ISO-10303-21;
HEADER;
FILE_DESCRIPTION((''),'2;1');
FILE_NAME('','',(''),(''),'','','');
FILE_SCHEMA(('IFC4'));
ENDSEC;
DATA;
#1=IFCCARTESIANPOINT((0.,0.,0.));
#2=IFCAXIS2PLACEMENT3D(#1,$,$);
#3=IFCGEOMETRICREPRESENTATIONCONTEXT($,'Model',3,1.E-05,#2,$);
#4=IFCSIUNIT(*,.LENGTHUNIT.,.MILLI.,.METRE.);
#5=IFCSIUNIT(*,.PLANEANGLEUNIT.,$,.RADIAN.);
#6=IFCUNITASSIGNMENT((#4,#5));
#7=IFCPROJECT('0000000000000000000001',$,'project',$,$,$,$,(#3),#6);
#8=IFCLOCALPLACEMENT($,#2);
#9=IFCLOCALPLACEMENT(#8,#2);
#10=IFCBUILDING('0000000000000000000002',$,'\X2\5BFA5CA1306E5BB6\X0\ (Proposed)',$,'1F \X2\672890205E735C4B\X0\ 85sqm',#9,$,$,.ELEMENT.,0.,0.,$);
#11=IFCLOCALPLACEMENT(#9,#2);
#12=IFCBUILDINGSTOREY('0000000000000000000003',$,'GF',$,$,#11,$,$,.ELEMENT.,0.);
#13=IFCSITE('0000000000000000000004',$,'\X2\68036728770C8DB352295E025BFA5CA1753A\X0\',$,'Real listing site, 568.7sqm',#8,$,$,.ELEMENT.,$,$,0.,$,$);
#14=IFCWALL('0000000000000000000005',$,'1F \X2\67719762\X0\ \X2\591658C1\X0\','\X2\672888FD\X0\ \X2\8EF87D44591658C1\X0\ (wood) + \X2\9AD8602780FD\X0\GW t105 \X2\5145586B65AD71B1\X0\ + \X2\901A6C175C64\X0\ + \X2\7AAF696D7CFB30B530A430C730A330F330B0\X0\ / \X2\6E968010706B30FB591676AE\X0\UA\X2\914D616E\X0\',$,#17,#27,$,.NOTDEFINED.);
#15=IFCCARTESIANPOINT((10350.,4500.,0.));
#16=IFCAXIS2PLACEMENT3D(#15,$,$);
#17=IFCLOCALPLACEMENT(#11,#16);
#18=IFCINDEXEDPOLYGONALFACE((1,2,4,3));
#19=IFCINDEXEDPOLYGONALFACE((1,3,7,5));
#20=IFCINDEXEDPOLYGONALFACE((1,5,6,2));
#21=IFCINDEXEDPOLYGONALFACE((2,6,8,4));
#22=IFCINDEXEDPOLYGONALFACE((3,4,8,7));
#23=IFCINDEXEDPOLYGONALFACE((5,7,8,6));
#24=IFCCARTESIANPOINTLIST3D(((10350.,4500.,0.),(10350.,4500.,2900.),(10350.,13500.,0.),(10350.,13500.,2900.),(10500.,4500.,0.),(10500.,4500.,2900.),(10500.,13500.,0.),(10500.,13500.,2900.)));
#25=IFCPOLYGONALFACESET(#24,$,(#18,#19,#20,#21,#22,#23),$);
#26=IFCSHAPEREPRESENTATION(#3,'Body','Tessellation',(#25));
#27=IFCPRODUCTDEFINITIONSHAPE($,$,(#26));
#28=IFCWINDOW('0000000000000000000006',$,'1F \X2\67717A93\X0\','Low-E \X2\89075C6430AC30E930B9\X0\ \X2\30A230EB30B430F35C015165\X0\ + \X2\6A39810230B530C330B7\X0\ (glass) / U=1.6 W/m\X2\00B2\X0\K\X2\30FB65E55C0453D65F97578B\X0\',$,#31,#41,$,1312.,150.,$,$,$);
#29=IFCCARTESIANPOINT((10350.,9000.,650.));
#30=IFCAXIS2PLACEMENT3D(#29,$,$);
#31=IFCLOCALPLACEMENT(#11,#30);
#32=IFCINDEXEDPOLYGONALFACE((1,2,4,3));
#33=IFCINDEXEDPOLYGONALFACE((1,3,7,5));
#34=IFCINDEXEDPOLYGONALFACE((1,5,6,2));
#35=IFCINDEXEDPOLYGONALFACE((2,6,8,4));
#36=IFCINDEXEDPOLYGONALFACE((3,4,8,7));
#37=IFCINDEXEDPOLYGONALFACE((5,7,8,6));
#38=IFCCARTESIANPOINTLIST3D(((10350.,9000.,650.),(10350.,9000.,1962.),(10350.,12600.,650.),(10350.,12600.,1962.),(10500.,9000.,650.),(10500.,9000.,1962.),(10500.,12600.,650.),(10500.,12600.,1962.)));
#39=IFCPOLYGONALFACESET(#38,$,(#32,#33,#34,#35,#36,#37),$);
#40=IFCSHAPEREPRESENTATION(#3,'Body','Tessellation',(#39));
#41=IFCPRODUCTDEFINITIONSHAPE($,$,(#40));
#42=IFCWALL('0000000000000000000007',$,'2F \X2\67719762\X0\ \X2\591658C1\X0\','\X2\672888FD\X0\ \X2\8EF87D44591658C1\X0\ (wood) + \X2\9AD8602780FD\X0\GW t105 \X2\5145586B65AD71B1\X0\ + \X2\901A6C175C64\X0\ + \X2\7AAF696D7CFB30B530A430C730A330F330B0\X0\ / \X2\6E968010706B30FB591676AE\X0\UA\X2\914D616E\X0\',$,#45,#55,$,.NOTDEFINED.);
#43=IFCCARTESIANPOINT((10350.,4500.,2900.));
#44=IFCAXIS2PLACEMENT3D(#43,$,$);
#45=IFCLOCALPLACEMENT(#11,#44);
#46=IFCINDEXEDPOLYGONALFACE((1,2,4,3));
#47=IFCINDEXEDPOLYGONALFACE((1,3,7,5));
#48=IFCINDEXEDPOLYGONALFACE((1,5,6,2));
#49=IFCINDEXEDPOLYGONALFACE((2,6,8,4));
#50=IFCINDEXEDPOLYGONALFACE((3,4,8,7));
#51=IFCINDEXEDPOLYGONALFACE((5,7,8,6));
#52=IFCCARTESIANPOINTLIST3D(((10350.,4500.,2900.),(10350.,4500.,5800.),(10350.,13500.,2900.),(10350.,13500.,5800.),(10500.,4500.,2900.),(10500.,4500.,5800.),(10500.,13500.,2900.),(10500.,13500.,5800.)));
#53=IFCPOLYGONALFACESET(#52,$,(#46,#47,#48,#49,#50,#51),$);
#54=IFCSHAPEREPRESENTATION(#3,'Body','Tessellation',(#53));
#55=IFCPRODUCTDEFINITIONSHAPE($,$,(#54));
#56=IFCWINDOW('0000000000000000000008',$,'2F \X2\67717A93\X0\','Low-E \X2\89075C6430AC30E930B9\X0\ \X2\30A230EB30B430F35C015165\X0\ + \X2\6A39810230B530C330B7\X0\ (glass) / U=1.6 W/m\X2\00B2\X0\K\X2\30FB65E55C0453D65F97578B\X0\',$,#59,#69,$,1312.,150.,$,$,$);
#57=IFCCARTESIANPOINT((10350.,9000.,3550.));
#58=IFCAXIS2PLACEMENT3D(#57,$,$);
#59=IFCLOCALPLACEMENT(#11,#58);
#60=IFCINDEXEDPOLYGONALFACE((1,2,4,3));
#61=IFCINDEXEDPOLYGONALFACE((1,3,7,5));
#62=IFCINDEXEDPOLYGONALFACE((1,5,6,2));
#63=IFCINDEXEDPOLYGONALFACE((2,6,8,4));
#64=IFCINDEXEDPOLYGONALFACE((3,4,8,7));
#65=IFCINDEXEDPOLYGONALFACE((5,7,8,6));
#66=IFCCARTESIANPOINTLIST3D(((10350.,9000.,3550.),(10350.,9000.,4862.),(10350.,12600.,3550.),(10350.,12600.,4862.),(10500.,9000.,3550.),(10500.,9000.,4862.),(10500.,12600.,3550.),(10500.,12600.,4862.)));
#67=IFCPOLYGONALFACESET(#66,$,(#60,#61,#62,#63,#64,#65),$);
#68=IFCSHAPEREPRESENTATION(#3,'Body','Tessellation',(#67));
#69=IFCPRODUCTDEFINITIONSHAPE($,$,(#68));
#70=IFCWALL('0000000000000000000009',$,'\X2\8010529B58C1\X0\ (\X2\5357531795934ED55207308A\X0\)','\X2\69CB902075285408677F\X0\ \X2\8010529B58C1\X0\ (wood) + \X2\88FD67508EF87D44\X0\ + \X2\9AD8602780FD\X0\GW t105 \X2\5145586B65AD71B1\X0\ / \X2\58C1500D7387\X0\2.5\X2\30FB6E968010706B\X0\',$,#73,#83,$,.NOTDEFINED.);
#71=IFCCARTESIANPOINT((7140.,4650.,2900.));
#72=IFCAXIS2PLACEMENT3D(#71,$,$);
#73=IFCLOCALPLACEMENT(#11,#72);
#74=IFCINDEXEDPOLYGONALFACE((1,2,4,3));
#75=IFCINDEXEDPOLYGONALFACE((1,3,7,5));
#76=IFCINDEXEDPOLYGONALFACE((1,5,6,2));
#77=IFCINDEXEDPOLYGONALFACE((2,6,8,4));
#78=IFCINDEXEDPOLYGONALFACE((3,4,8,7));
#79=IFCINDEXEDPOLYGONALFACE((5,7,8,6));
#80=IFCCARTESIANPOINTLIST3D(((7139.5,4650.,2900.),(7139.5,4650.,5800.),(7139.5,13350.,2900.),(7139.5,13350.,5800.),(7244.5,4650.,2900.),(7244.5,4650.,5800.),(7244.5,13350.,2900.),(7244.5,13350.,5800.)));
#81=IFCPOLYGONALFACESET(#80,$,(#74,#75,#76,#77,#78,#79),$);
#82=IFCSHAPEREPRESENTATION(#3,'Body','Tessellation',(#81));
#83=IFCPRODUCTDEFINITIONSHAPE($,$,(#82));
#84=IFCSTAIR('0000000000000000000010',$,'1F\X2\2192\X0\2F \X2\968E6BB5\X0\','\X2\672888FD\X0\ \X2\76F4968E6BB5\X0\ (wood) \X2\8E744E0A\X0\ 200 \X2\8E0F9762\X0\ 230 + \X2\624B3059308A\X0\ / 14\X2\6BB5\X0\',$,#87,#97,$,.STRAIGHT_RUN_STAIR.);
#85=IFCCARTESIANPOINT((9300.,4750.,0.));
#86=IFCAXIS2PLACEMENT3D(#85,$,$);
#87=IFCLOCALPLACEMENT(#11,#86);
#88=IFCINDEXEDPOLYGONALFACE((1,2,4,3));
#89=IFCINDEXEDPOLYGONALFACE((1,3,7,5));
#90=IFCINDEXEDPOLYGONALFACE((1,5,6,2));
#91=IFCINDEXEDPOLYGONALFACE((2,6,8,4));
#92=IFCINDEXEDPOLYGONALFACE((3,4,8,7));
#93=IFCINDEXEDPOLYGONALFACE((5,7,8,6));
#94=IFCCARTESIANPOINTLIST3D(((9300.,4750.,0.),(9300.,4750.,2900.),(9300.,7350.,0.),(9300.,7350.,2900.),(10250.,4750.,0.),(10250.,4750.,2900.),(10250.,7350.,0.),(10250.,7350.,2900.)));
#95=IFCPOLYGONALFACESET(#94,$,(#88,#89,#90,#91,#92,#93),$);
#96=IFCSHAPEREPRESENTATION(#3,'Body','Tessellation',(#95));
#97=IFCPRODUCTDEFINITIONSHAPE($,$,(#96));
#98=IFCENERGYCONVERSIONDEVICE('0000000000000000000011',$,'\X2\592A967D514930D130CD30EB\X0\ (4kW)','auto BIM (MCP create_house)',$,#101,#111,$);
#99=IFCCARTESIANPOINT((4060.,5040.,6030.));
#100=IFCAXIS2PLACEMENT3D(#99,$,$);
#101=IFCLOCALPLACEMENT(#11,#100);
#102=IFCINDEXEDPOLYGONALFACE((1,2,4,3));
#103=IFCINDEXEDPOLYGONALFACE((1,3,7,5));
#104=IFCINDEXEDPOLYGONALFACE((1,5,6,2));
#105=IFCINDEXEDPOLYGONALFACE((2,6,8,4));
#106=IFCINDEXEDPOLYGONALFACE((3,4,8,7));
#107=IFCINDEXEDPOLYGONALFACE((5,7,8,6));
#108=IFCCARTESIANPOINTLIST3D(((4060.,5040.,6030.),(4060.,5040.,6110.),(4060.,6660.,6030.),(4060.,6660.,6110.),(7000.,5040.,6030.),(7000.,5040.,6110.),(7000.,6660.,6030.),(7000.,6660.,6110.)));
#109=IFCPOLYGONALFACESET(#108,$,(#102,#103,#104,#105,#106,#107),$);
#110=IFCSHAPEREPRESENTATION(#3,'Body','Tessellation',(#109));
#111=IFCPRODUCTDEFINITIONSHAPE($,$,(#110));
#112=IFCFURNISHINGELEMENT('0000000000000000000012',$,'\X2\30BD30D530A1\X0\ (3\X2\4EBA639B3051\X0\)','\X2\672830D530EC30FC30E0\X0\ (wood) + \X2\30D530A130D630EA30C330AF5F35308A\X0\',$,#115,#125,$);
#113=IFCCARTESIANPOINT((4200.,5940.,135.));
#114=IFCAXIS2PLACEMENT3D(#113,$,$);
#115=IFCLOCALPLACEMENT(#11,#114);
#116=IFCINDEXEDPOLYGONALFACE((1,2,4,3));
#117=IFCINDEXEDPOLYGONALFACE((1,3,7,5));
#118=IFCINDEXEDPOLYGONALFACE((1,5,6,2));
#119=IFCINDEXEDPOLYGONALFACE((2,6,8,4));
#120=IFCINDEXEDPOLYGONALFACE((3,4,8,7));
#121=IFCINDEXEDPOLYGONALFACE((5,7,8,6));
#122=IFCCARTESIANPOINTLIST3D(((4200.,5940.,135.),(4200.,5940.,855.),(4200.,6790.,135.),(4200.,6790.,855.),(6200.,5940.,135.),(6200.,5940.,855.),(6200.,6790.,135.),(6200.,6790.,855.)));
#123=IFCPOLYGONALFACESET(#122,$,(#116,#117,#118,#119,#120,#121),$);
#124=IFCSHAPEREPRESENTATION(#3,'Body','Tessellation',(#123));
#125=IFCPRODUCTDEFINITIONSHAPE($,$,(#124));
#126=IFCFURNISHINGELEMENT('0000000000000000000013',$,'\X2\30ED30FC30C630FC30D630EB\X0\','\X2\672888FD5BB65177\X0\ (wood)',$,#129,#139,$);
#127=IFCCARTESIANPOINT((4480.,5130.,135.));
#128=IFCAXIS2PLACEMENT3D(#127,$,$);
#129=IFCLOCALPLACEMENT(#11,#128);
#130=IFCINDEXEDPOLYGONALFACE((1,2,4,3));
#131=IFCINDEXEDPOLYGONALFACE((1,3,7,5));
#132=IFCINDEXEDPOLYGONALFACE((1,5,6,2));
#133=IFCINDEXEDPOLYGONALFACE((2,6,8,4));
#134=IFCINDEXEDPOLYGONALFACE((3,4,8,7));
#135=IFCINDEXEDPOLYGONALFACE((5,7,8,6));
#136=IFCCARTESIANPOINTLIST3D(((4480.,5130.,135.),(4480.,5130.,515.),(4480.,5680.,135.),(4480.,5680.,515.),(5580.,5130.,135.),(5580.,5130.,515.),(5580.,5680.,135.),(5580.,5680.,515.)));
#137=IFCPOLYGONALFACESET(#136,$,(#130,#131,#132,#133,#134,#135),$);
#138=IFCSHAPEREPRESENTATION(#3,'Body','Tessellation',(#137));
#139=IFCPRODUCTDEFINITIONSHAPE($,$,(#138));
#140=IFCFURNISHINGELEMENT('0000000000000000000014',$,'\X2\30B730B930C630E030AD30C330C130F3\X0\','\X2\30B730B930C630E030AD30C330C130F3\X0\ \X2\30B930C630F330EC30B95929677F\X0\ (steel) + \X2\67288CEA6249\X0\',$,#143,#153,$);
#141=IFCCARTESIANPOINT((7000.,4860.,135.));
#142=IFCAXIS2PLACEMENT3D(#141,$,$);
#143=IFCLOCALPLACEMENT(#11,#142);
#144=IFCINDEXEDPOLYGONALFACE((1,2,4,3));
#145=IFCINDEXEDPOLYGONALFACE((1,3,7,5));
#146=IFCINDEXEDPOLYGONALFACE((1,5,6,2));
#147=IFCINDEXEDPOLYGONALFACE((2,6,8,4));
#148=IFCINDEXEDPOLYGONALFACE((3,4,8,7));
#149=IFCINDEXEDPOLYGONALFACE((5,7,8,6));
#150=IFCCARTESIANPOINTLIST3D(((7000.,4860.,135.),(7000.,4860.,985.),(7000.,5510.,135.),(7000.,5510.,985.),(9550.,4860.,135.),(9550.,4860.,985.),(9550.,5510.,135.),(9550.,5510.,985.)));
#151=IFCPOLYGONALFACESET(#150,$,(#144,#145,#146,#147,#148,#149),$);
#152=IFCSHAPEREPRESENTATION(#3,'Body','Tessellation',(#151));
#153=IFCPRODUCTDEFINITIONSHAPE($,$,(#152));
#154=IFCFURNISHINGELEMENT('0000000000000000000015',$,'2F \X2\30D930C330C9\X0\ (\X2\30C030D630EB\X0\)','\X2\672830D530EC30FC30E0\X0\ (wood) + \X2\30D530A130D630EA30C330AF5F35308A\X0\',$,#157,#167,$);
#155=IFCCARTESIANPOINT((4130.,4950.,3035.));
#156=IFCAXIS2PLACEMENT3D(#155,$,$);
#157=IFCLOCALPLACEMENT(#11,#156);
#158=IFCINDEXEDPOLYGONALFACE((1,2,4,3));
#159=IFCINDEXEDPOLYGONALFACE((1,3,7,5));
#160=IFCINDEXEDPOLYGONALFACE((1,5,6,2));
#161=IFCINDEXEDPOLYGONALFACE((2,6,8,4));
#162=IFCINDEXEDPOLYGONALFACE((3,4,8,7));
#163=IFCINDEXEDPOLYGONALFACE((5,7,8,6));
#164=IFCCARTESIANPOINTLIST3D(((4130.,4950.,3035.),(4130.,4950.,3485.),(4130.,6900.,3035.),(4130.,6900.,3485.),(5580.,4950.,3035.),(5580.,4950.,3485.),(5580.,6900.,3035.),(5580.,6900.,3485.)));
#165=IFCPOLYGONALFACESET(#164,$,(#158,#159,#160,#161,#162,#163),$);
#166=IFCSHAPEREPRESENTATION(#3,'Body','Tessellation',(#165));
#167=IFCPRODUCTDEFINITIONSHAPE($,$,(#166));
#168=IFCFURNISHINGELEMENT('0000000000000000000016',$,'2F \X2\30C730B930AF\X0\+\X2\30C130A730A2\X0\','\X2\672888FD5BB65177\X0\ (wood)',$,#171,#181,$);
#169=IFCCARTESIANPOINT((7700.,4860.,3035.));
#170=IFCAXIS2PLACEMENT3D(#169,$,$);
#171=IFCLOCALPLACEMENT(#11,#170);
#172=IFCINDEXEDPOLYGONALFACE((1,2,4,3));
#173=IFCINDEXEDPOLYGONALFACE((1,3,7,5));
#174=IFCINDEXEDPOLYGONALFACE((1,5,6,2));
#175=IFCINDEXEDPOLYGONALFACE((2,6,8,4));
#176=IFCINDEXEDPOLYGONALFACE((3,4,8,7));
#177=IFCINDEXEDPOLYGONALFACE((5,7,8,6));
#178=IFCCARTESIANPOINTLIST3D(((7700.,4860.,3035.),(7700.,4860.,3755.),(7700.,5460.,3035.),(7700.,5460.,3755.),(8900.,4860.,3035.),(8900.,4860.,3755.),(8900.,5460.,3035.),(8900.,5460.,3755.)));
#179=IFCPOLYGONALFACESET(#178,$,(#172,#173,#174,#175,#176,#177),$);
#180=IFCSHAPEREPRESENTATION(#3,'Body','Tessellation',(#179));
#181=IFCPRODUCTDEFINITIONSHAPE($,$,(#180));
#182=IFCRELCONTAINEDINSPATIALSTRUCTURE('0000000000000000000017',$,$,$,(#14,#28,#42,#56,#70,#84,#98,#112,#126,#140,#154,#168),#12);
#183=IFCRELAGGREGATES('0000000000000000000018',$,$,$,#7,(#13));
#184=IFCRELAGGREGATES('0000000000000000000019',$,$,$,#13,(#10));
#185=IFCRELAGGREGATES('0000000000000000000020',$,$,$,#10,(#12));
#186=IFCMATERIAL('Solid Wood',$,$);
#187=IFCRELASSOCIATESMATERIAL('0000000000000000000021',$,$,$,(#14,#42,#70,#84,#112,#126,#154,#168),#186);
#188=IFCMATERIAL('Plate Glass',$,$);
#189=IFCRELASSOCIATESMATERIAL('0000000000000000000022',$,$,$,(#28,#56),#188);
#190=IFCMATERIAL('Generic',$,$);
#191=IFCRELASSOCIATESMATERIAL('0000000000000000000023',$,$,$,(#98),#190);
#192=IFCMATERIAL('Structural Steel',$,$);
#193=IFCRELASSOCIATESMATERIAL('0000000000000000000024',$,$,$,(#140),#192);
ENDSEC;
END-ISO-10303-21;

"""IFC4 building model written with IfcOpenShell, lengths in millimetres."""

from ifc_helpers import new_model, si_unit, frame, frame_2d, origin, place, context, project, spatial, rectangle, extrude, material, element, fill, save


model = new_model("IFC4")

# Units and contexts
model_context = context("Model", 3, precision=1e-05, world=origin())
ifc_project = project(units=[si_unit("LENGTHUNIT", "METRE", prefix="MILLI"), si_unit("PLANEANGLEUNIT", "RADIAN")], contexts=[model_context])

# Site, building, storey
site_placement = place(None, origin())
site = spatial("IfcSite", under=ifc_project, at=site_placement, Name="栃木県足利市寺岡町", ObjectType="Real listing site, 568.7sqm", CompositionType="ELEMENT", RefElevation=0.0)
building_placement = place(site_placement, origin())
building = spatial("IfcBuilding", under=site, at=building_placement, Name="寺岡の家 (Proposed)", ObjectType="1F 木造平屋 85sqm", CompositionType="ELEMENT", ElevationOfRefHeight=0.0, ElevationOfTerrain=0.0)
storey_placement = place(building_placement, origin())
storey = spatial("IfcBuildingStorey", under=building, at=storey_placement, Name="GF", CompositionType="ELEMENT", Elevation=0.0)

# Wall, opening, window
ifc_material_1 = material(Name="Solid Wood")
wall_1_placement = place(storey_placement, frame((10350.0, 4500.0, 0.0)))
wall_1 = element("IfcWall", 1, at=wall_1_placement, inside=storey, material=ifc_material_1, Name="1F 東面 外壁", Description="木製 軸組外壁 (wood) + 高性能GW t105 充填断熱 + 通気層 + 窯業系サイディング / 準耐火・外皮UA配慮", PredefinedType="NOTDEFINED", context=model_context, shape_type="SweptSolid", body=[
    extrude(rectangle(XDim=150.0, YDim=9000.0, at=frame_2d((75.0, 4500.0))), frame((10350.0, 4500.0, 0.0)), (0.0, 0.0, 1.0), 2900.0),
])
opening_1_placement = place(storey_placement, frame((10350.0, 9000.0, 650.0)))
opening_1 = element("IfcOpeningElement", 2, at=opening_1_placement, cuts=wall_1, PredefinedType="NOTDEFINED", context=model_context, shape_type="SweptSolid", body=[
    extrude(rectangle(XDim=150.0, YDim=3600.0, at=frame_2d((75.0, 1800.0))), frame((10350.0, 9000.0, 650.0)), (0.0, 0.0, 1.0), 1312.0),
])
ifc_material_2 = material(Name="Plate Glass")
window_1_placement = place(storey_placement, frame((10350.0, 9000.0, 650.0)))
window_1 = element("IfcWindow", 3, at=window_1_placement, inside=storey, material=ifc_material_2, Name="1F 東窓", Description="Low-E 複層ガラス アルゴン封入 + 樹脂サッシ (glass) / U=1.6 W/m²K・日射取得型", OverallHeight=1312.0, OverallWidth=150.0, context=model_context, shape_type="SweptSolid", body=[
    extrude(rectangle(XDim=150.0, YDim=3600.0, at=frame_2d((75.0, 1800.0))), frame((10350.0, 9000.0, 650.0)), (0.0, 0.0, 1.0), 1312.0),
])
fill(opening_1, window_1)

# Wall, opening, window
wall_2_placement = place(storey_placement, frame((10350.0, 4500.0, 2900.0)))
wall_2 = element("IfcWall", 4, at=wall_2_placement, inside=storey, material=ifc_material_1, Name="2F 東面 外壁", Description="木製 軸組外壁 (wood) + 高性能GW t105 充填断熱 + 通気層 + 窯業系サイディング / 準耐火・外皮UA配慮", PredefinedType="NOTDEFINED", context=model_context, shape_type="SweptSolid", body=[
    extrude(rectangle(XDim=150.0, YDim=9000.0, at=frame_2d((75.0, 4500.0))), frame((10350.0, 4500.0, 2900.0)), (0.0, 0.0, 1.0), 2900.0),
])
opening_2_placement = place(storey_placement, frame((10350.0, 9000.0, 3550.0)))
opening_2 = element("IfcOpeningElement", 5, at=opening_2_placement, cuts=wall_2, PredefinedType="NOTDEFINED", context=model_context, shape_type="SweptSolid", body=[
    extrude(rectangle(XDim=150.0, YDim=3600.0, at=frame_2d((75.0, 1800.0))), frame((10350.0, 9000.0, 3550.0)), (0.0, 0.0, 1.0), 1312.0),
])
window_2_placement = place(storey_placement, frame((10350.0, 9000.0, 3550.0)))
window_2 = element("IfcWindow", 6, at=window_2_placement, inside=storey, material=ifc_material_2, Name="2F 東窓", Description="Low-E 複層ガラス アルゴン封入 + 樹脂サッシ (glass) / U=1.6 W/m²K・日射取得型", OverallHeight=1312.0, OverallWidth=150.0, context=model_context, shape_type="SweptSolid", body=[
    extrude(rectangle(XDim=150.0, YDim=3600.0, at=frame_2d((75.0, 1800.0))), frame((10350.0, 9000.0, 3550.0)), (0.0, 0.0, 1.0), 1312.0),
])
fill(opening_2, window_2)

# Wall
wall_3_placement = place(storey_placement, frame((7140.0, 4650.0, 2900.0)))
element("IfcWall", 7, at=wall_3_placement, inside=storey, material=ifc_material_1, Name="耐力壁 (南北間仕切り)", Description="構造用合板 耐力壁 (wood) + 製材軸組 + 高性能GW t105 充填断熱 / 壁倍率2.5・準耐火", PredefinedType="NOTDEFINED", context=model_context, shape_type="SweptSolid", body=[
    extrude(rectangle(XDim=105.0, YDim=8700.0, at=frame_2d((52.0, 4350.0))), frame((7140.0, 4650.0, 2900.0)), (0.0, 0.0, 1.0), 2900.0),
])

# Stair
stair_placement = place(storey_placement, frame((9300.0, 4750.0, 0.0)))
element("IfcStair", 8, at=stair_placement, inside=storey, material=ifc_material_1, Name="1F→2F 階段", Description="木製 直階段 (wood) 蹴上 200 踏面 230 + 手すり / 14段", PredefinedType="STRAIGHT_RUN_STAIR", context=model_context, shape_type="SweptSolid", body=[
    extrude(rectangle(XDim=950.0, YDim=2600.0, at=frame_2d((475.0, 1300.0))), frame((9300.0, 4750.0, 0.0)), (0.0, 0.0, 1.0), 2900.0),
])

# Energy conversion device
ifc_material_3 = material(Name="Generic")
energy_conversion_device_placement = place(storey_placement, frame((4060.0, 5040.0, 6030.0)))
element("IfcEnergyConversionDevice", 9, at=energy_conversion_device_placement, inside=storey, material=ifc_material_3, Name="太陽光パネル (4kW)", Description="auto BIM (MCP create_house)", context=model_context, shape_type="SweptSolid", body=[
    extrude(rectangle(XDim=2940.0, YDim=1620.0, at=frame_2d((1470.0, 810.0))), frame((4060.0, 5040.0, 6030.0)), (0.0, 0.0, 1.0), 80.0),
])

# Furnishing elements
furnishing_1_placement = place(storey_placement, frame((4200.0, 5940.0, 135.0)))
element("IfcFurnishingElement", 10, at=furnishing_1_placement, inside=storey, material=ifc_material_1, Name="ソファ (3人掛け)", Description="木フレーム (wood) + ファブリック張り", context=model_context, shape_type="SweptSolid", body=[
    extrude(rectangle(XDim=2000.0, YDim=850.0, at=frame_2d((1000.0, 425.0))), frame((4200.0, 5940.0, 135.0)), (0.0, 0.0, 1.0), 720.0),
])
furnishing_2_placement = place(storey_placement, frame((4480.0, 5130.0, 135.0)))
element("IfcFurnishingElement", 11, at=furnishing_2_placement, inside=storey, material=ifc_material_1, Name="ローテーブル", Description="木製家具 (wood)", context=model_context, shape_type="SweptSolid", body=[
    extrude(rectangle(XDim=1100.0, YDim=550.0, at=frame_2d((550.0, 275.0))), frame((4480.0, 5130.0, 135.0)), (0.0, 0.0, 1.0), 380.0),
])
ifc_material_4 = material(Name="Structural Steel")
furnishing_3_placement = place(storey_placement, frame((7000.0, 4860.0, 135.0)))
element("IfcFurnishingElement", 12, at=furnishing_3_placement, inside=storey, material=ifc_material_4, Name="システムキッチン", Description="システムキッチン ステンレス天板 (steel) + 木質扉", context=model_context, shape_type="SweptSolid", body=[
    extrude(rectangle(XDim=2550.0, YDim=650.0, at=frame_2d((1275.0, 325.0))), frame((7000.0, 4860.0, 135.0)), (0.0, 0.0, 1.0), 850.0),
])
furnishing_4_placement = place(storey_placement, frame((4130.0, 4950.0, 3035.0)))
element("IfcFurnishingElement", 13, at=furnishing_4_placement, inside=storey, material=ifc_material_1, Name="2F ベッド (ダブル)", Description="木フレーム (wood) + ファブリック張り", context=model_context, shape_type="SweptSolid", body=[
    extrude(rectangle(XDim=1450.0, YDim=1950.0, at=frame_2d((725.0, 975.0))), frame((4130.0, 4950.0, 3035.0)), (0.0, 0.0, 1.0), 450.0),
])
furnishing_5_placement = place(storey_placement, frame((7700.0, 4860.0, 3035.0)))
element("IfcFurnishingElement", 14, at=furnishing_5_placement, inside=storey, material=ifc_material_1, Name="2F デスク+チェア", Description="木製家具 (wood)", context=model_context, shape_type="SweptSolid", body=[
    extrude(rectangle(XDim=1200.0, YDim=600.0, at=frame_2d((600.0, 300.0))), frame((7700.0, 4860.0, 3035.0)), (0.0, 0.0, 1.0), 720.0),
])

save(model, "model.ifc")
